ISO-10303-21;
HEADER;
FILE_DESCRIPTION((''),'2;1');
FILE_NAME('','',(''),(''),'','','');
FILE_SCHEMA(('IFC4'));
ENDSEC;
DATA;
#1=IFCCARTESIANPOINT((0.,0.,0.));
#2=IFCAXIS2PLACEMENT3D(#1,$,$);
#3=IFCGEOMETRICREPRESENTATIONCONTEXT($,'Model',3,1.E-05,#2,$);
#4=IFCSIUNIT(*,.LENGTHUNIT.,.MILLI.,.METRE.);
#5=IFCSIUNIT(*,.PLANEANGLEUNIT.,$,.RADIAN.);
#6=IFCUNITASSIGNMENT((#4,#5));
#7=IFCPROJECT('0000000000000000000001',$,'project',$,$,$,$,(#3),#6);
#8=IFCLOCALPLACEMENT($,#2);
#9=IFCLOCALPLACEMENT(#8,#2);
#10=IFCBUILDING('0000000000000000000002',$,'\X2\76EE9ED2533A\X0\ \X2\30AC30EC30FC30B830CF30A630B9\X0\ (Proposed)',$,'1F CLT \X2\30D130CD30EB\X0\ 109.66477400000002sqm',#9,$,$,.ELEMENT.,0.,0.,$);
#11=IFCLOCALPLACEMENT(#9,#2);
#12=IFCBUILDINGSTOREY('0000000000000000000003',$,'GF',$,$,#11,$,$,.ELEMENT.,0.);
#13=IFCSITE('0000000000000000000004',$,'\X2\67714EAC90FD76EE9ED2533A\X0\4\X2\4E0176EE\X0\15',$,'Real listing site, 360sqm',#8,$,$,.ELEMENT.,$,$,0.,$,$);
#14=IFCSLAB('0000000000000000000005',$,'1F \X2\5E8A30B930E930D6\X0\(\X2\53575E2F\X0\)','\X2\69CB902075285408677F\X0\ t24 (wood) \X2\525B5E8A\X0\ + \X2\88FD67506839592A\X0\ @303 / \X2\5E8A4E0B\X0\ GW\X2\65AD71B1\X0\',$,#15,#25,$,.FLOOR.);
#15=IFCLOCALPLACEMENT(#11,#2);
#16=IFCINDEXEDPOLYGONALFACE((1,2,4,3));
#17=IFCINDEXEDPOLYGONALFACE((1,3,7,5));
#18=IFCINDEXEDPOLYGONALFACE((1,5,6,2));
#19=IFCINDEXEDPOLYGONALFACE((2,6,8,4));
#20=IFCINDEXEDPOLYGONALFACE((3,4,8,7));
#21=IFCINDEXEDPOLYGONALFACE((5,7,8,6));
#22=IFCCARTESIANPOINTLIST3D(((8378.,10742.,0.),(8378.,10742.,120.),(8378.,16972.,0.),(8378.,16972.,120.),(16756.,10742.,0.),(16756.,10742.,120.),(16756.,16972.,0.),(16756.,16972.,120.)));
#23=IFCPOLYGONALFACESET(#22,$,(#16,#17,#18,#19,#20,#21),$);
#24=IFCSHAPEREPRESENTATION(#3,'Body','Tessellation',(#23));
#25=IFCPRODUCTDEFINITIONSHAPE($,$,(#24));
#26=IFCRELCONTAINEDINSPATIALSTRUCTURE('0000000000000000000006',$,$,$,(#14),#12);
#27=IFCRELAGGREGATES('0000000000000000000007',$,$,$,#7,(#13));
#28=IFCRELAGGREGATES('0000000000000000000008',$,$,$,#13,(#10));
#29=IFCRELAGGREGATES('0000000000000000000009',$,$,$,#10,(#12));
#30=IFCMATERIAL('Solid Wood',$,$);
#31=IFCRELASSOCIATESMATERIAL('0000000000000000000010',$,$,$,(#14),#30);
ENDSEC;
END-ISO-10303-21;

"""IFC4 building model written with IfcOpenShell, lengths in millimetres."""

from ifc_helpers import new_model, si_unit, frame, frame_2d, origin, place, context, project, spatial, rectangle, extrude, material, element, save


model = new_model("IFC4")

# Units and contexts
model_context = context("Model", 3, precision=1e-05, world=origin())
ifc_project = project(units=[si_unit("LENGTHUNIT", "METRE", prefix="MILLI"), si_unit("PLANEANGLEUNIT", "RADIAN")], contexts=[model_context])

# Site, building, storey
site_placement = place(None, origin())
site = spatial("IfcSite", under=ifc_project, at=site_placement, Name="東京都目黒区4丁目15", ObjectType="Real listing site, 360sqm", CompositionType="ELEMENT", RefElevation=0.0)
building_placement = place(site_placement, origin())
building = spatial("IfcBuilding", under=site, at=building_placement, Name="目黒区 ガレージハウス (Proposed)", ObjectType="1F CLT パネル 109.66477400000002sqm", CompositionType="ELEMENT", ElevationOfRefHeight=0.0, ElevationOfTerrain=0.0)
storey_placement = place(building_placement, origin())
storey = spatial("IfcBuildingStorey", under=building, at=storey_placement, Name="GF", CompositionType="ELEMENT", Elevation=0.0)

# Slab
ifc_material_1 = material(Name="Solid Wood")
slab_1_placement = place(storey_placement, frame((4189.0, 5371.0, 0.0)))
element("IfcSlab", 1, at=slab_1_placement, inside=storey, material=ifc_material_1, Name="1F 床スラブ(南帯)", Description="構造用合板 t24 (wood) 剛床 + 製材根太 @303 / 床下 GW断熱", PredefinedType="FLOOR", context=model_context, shape_type="SweptSolid", body=[
    extrude(rectangle(XDim=8378.0, YDim=6230.0, at=frame_2d((4189.0, 3115.0))), frame((4189.0, 5371.0, 0.0)), (0.0, 0.0, 1.0), 120.0),
])

save(model, "model.ifc")
